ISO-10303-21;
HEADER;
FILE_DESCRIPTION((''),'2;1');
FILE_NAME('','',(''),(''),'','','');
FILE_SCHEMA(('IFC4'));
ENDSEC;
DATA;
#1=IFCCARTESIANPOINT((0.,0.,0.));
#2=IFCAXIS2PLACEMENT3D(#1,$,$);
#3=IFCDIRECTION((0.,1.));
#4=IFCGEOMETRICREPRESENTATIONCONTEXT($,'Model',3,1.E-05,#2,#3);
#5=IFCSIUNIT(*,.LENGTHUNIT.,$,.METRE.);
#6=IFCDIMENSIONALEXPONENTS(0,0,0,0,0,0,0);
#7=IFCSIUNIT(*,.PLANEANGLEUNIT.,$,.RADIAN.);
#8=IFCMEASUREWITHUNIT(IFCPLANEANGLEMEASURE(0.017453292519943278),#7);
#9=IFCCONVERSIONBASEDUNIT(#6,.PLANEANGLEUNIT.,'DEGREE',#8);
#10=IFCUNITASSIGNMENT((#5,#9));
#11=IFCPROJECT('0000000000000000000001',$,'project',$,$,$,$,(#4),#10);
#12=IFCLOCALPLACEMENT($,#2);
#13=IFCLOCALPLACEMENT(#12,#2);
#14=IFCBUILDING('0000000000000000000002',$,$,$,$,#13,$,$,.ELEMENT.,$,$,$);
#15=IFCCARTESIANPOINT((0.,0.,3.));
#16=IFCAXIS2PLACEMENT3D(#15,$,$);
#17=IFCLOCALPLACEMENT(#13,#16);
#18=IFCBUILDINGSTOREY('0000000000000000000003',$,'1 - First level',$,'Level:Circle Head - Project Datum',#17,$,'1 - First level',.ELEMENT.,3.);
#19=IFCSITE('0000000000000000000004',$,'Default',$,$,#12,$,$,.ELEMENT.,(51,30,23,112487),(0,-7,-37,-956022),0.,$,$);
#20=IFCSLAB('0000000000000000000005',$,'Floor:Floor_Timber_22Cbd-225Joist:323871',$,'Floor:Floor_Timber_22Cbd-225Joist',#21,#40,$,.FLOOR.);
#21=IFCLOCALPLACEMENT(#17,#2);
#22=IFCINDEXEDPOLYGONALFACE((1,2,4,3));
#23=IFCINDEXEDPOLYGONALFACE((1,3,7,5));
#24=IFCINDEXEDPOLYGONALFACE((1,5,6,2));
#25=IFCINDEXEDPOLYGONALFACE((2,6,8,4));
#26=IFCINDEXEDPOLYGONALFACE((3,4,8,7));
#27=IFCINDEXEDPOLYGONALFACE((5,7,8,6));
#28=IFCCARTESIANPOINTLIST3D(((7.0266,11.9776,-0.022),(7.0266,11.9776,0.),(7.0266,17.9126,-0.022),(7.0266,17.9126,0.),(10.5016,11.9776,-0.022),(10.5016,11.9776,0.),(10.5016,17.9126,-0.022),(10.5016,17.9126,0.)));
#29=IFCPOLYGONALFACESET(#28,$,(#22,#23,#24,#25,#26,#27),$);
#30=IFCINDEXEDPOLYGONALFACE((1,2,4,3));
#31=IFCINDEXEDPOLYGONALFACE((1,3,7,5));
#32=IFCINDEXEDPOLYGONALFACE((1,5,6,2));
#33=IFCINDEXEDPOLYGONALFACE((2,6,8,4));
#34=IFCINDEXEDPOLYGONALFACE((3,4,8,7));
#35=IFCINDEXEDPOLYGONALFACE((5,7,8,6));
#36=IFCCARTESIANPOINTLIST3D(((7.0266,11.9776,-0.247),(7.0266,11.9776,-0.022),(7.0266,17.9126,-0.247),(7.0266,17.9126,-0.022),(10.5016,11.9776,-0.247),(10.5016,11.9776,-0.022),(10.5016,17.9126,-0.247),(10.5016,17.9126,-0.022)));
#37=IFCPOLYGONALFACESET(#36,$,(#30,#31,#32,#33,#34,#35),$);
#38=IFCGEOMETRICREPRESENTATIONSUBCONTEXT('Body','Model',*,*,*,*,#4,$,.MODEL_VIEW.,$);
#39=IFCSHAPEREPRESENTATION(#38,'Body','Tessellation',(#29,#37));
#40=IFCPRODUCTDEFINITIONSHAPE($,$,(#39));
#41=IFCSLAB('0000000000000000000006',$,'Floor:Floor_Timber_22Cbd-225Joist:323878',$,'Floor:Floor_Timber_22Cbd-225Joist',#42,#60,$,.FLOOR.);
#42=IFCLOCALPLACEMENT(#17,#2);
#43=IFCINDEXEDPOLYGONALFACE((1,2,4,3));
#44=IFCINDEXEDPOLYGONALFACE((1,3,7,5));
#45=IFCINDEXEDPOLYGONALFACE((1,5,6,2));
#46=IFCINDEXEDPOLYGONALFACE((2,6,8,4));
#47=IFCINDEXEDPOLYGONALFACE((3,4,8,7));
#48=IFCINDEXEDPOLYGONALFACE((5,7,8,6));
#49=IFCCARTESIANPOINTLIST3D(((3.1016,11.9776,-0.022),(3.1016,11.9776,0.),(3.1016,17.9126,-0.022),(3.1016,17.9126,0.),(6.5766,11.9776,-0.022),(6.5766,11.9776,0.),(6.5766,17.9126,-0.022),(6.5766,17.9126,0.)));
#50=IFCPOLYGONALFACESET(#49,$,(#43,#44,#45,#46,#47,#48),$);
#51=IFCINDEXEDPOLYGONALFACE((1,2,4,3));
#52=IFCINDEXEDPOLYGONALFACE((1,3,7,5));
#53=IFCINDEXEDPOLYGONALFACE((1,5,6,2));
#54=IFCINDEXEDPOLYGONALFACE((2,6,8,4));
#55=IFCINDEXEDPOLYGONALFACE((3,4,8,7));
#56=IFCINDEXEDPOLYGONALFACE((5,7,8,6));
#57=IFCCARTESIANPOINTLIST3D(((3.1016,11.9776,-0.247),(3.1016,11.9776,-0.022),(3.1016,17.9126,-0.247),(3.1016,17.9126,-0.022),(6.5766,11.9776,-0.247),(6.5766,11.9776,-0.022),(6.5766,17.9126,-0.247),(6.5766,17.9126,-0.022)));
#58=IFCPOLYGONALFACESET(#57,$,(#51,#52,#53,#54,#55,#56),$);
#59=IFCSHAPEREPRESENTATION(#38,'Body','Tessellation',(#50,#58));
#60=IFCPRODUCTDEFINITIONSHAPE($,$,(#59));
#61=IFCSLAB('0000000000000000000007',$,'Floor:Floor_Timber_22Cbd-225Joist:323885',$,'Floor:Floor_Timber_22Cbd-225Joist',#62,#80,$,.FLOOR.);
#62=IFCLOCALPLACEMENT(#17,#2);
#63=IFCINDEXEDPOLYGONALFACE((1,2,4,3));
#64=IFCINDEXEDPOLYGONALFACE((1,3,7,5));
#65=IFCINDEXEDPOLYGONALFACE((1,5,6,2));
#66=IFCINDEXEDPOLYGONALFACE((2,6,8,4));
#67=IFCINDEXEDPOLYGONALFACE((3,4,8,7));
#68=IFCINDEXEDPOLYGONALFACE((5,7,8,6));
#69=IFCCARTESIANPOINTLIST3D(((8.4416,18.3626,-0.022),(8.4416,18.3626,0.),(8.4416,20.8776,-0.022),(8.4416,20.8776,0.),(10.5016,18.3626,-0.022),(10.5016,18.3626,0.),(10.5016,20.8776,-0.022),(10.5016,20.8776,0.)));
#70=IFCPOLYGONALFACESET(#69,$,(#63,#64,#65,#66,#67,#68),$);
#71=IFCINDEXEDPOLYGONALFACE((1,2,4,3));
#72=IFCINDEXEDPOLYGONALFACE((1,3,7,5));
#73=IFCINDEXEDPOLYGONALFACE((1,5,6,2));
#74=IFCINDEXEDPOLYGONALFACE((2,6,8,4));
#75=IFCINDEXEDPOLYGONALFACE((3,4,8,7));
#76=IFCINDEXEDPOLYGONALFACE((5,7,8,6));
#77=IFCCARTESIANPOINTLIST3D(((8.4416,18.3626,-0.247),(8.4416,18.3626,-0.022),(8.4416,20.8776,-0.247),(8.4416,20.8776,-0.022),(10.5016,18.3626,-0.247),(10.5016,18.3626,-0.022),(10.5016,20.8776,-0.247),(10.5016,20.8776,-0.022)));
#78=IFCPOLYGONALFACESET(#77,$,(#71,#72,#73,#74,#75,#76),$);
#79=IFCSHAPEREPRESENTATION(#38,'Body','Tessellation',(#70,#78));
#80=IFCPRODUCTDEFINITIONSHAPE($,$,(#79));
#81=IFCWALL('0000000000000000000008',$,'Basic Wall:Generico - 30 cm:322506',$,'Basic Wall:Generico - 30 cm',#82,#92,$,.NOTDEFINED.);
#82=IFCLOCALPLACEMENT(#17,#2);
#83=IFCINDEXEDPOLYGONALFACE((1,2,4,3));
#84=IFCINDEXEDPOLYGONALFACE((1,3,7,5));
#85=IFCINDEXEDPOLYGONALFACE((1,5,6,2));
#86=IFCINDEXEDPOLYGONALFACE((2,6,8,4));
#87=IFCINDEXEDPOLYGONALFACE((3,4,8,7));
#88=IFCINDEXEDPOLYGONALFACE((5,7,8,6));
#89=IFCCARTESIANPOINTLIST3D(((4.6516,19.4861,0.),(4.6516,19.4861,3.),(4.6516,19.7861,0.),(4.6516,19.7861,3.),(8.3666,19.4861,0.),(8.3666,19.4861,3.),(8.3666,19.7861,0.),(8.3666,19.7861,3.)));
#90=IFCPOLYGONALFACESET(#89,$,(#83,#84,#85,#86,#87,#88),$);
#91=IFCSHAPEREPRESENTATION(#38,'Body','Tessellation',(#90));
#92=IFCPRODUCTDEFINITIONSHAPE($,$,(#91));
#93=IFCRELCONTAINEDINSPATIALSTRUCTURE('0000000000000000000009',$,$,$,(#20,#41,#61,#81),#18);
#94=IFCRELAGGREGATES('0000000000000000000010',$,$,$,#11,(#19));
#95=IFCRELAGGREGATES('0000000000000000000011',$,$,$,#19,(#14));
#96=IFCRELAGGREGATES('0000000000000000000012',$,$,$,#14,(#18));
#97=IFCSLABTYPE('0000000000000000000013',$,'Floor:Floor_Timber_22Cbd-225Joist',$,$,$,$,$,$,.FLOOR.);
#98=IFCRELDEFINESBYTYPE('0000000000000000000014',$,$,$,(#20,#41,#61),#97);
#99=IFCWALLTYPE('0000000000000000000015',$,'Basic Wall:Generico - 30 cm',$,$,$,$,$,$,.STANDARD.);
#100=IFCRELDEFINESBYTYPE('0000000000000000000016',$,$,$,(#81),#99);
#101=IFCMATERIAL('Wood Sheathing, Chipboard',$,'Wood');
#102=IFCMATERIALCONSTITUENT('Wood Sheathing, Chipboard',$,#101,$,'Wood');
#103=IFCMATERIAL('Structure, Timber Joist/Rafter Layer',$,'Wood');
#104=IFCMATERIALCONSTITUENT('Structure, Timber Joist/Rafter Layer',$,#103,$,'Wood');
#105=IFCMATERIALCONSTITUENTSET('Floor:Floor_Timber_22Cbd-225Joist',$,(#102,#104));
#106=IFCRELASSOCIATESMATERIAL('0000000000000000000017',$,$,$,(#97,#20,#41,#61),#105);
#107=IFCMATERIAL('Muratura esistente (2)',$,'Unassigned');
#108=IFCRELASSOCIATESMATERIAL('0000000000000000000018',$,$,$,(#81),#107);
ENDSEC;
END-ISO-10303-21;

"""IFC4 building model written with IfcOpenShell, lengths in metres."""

from ifc_helpers import new_model, entity, si_unit, converted_unit, direction, frame, origin, place, context, subcontext, project, spatial, indexed_curve, outline, extrude, material, constituent, constituent_set, type_object, element, save


model = new_model("IFC4")

# Units and contexts
model_context = context("Model", 3, precision=1e-05, world=origin(), true_north=direction((0.0, 1.0)))
body_context = subcontext(model_context, "Body", "Model", "MODEL_VIEW")
ifc_project = project(units=[si_unit("LENGTHUNIT", "METRE"), converted_unit("PLANEANGLEUNIT", "DEGREE", entity("IfcPlaneAngleMeasure", 0.017453292519943278), si_unit("PLANEANGLEUNIT", "RADIAN"), dimensions=[0, 0, 0, 0, 0, 0, 0])], contexts=[model_context])

# Site, building, storey
site_placement = place(None, origin())
site = spatial("IfcSite", under=ifc_project, at=site_placement, Name="Default", CompositionType="ELEMENT", RefLatitude=(51, 30, 23, 112487), RefLongitude=(0, -7, -37, -956022), RefElevation=0.0)
building_placement = place(site_placement, origin())
building = spatial("IfcBuilding", under=site, at=building_placement, CompositionType="ELEMENT")
storey_placement = place(building_placement, frame((0.0, 0.0, 3.0)))
storey = spatial("IfcBuildingStorey", under=building, at=storey_placement, Name="1 - First level", ObjectType="Level:Circle Head - Project Datum", LongName="1 - First level", CompositionType="ELEMENT", Elevation=3.0)

# Slabs
ifc_material_1 = material(Name="Wood Sheathing, Chipboard", Category="Wood")
ifc_constituent_1 = constituent(ifc_material_1, Name="Wood Sheathing, Chipboard", Category="Wood")
ifc_material_2 = material(Name="Structure, Timber Joist/Rafter Layer", Category="Wood")
ifc_constituent_2 = constituent(ifc_material_2, Name="Structure, Timber Joist/Rafter Layer", Category="Wood")
ifc_constituent_set = constituent_set(constituents=[ifc_constituent_1, ifc_constituent_2], Name="Floor:Floor_Timber_22Cbd-225Joist")
slab_type = type_object("IfcSlabType", Name="Floor:Floor_Timber_22Cbd-225Joist", PredefinedType="FLOOR", material=ifc_constituent_set)
slab_1_placement = place(storey_placement, origin())
element("IfcSlab", 1, at=slab_1_placement, inside=storey, type_object=slab_type, material=ifc_constituent_set, Name="Floor:Floor_Timber_22Cbd-225Joist:323871", ObjectType="Floor:Floor_Timber_22Cbd-225Joist", PredefinedType="FLOOR", context=body_context, shape_type="SweptSolid", body=[
    extrude(outline(indexed_curve([(-2.9675, -1.7375), (2.9675, -1.7375), (2.9675, 1.7375), (-2.9675, 1.7375), (-2.9675, -1.7375)], self_intersect=False)), frame((8.7641, 14.9451, -0.022), z_axis=(0.0, 0.0, 1.0), x_axis=(0.0, -1.0, 0.0)), (0.0, 0.0, 1.0), 0.022),
    extrude(outline(indexed_curve([(-2.9675, -1.7375), (2.9675, -1.7375), (2.9675, 1.7375), (-2.9675, 1.7375), (-2.9675, -1.7375)], self_intersect=False)), frame((8.7641, 14.9451, -0.247), z_axis=(0.0, 0.0, 1.0), x_axis=(0.0, -1.0, 0.0)), (0.0, 0.0, 1.0), 0.225),
])
slab_2_placement = place(storey_placement, origin())
element("IfcSlab", 2, at=slab_2_placement, inside=storey, type_object=slab_type, material=ifc_constituent_set, Name="Floor:Floor_Timber_22Cbd-225Joist:323878", ObjectType="Floor:Floor_Timber_22Cbd-225Joist", PredefinedType="FLOOR", context=body_context, shape_type="SweptSolid", body=[
    extrude(outline(indexed_curve([(-1.7375, -2.9675), (1.7375, -2.9675), (1.7375, 2.9675), (-1.7375, 2.9675), (-1.7375, -2.9675)], self_intersect=False)), frame((4.8391, 14.9451, -0.022)), (0.0, 0.0, 1.0), 0.022),
    extrude(outline(indexed_curve([(-1.7375, -2.9675), (1.7375, -2.9675), (1.7375, 2.9675), (-1.7375, 2.9675), (-1.7375, -2.9675)], self_intersect=False)), frame((4.8391, 14.9451, -0.247)), (0.0, 0.0, 1.0), 0.225),
])
slab_3_placement = place(storey_placement, origin())
element("IfcSlab", 3, at=slab_3_placement, inside=storey, type_object=slab_type, material=ifc_constituent_set, Name="Floor:Floor_Timber_22Cbd-225Joist:323885", ObjectType="Floor:Floor_Timber_22Cbd-225Joist", PredefinedType="FLOOR", context=body_context, shape_type="SweptSolid", body=[
    extrude(outline(indexed_curve([(-1.2575, -1.03), (1.2575, -1.03), (1.2575, 1.03), (-1.2575, 1.03), (-1.2575, -1.03)], self_intersect=False)), frame((9.4716, 19.6201, -0.022), z_axis=(0.0, 0.0, 1.0), x_axis=(0.0, -1.0, 0.0)), (0.0, 0.0, 1.0), 0.022),
    extrude(outline(indexed_curve([(-1.2575, -1.03), (1.2575, -1.03), (1.2575, 1.03), (-1.2575, 1.03), (-1.2575, -1.03)], self_intersect=False)), frame((9.4716, 19.6201, -0.247), z_axis=(0.0, 0.0, 1.0), x_axis=(0.0, -1.0, 0.0)), (0.0, 0.0, 1.0), 0.225),
])

# Wall
ifc_material_3 = material(Name="Muratura esistente (2)", Category="Unassigned")
wall_type = type_object("IfcWallType", Name="Basic Wall:Generico - 30 cm", PredefinedType="STANDARD")
wall_placement = place(storey_placement, frame((4.6516, 19.6361, 0.0)))
element("IfcWall", 4, at=wall_placement, inside=storey, type_object=wall_type, material=ifc_material_3, Name="Basic Wall:Generico - 30 cm:322506", ObjectType="Basic Wall:Generico - 30 cm", PredefinedType="NOTDEFINED", context=body_context, shape_type="SweptSolid", body=[
    extrude(outline(indexed_curve([(3.715, 0.15), (0.0, 0.15), (0.0, -0.15), (3.715, -0.15), (3.715, 0.15)], self_intersect=False)), origin(), (0.0, 0.0, 1.0), 3.0),
])

save(model, "model.ifc")
